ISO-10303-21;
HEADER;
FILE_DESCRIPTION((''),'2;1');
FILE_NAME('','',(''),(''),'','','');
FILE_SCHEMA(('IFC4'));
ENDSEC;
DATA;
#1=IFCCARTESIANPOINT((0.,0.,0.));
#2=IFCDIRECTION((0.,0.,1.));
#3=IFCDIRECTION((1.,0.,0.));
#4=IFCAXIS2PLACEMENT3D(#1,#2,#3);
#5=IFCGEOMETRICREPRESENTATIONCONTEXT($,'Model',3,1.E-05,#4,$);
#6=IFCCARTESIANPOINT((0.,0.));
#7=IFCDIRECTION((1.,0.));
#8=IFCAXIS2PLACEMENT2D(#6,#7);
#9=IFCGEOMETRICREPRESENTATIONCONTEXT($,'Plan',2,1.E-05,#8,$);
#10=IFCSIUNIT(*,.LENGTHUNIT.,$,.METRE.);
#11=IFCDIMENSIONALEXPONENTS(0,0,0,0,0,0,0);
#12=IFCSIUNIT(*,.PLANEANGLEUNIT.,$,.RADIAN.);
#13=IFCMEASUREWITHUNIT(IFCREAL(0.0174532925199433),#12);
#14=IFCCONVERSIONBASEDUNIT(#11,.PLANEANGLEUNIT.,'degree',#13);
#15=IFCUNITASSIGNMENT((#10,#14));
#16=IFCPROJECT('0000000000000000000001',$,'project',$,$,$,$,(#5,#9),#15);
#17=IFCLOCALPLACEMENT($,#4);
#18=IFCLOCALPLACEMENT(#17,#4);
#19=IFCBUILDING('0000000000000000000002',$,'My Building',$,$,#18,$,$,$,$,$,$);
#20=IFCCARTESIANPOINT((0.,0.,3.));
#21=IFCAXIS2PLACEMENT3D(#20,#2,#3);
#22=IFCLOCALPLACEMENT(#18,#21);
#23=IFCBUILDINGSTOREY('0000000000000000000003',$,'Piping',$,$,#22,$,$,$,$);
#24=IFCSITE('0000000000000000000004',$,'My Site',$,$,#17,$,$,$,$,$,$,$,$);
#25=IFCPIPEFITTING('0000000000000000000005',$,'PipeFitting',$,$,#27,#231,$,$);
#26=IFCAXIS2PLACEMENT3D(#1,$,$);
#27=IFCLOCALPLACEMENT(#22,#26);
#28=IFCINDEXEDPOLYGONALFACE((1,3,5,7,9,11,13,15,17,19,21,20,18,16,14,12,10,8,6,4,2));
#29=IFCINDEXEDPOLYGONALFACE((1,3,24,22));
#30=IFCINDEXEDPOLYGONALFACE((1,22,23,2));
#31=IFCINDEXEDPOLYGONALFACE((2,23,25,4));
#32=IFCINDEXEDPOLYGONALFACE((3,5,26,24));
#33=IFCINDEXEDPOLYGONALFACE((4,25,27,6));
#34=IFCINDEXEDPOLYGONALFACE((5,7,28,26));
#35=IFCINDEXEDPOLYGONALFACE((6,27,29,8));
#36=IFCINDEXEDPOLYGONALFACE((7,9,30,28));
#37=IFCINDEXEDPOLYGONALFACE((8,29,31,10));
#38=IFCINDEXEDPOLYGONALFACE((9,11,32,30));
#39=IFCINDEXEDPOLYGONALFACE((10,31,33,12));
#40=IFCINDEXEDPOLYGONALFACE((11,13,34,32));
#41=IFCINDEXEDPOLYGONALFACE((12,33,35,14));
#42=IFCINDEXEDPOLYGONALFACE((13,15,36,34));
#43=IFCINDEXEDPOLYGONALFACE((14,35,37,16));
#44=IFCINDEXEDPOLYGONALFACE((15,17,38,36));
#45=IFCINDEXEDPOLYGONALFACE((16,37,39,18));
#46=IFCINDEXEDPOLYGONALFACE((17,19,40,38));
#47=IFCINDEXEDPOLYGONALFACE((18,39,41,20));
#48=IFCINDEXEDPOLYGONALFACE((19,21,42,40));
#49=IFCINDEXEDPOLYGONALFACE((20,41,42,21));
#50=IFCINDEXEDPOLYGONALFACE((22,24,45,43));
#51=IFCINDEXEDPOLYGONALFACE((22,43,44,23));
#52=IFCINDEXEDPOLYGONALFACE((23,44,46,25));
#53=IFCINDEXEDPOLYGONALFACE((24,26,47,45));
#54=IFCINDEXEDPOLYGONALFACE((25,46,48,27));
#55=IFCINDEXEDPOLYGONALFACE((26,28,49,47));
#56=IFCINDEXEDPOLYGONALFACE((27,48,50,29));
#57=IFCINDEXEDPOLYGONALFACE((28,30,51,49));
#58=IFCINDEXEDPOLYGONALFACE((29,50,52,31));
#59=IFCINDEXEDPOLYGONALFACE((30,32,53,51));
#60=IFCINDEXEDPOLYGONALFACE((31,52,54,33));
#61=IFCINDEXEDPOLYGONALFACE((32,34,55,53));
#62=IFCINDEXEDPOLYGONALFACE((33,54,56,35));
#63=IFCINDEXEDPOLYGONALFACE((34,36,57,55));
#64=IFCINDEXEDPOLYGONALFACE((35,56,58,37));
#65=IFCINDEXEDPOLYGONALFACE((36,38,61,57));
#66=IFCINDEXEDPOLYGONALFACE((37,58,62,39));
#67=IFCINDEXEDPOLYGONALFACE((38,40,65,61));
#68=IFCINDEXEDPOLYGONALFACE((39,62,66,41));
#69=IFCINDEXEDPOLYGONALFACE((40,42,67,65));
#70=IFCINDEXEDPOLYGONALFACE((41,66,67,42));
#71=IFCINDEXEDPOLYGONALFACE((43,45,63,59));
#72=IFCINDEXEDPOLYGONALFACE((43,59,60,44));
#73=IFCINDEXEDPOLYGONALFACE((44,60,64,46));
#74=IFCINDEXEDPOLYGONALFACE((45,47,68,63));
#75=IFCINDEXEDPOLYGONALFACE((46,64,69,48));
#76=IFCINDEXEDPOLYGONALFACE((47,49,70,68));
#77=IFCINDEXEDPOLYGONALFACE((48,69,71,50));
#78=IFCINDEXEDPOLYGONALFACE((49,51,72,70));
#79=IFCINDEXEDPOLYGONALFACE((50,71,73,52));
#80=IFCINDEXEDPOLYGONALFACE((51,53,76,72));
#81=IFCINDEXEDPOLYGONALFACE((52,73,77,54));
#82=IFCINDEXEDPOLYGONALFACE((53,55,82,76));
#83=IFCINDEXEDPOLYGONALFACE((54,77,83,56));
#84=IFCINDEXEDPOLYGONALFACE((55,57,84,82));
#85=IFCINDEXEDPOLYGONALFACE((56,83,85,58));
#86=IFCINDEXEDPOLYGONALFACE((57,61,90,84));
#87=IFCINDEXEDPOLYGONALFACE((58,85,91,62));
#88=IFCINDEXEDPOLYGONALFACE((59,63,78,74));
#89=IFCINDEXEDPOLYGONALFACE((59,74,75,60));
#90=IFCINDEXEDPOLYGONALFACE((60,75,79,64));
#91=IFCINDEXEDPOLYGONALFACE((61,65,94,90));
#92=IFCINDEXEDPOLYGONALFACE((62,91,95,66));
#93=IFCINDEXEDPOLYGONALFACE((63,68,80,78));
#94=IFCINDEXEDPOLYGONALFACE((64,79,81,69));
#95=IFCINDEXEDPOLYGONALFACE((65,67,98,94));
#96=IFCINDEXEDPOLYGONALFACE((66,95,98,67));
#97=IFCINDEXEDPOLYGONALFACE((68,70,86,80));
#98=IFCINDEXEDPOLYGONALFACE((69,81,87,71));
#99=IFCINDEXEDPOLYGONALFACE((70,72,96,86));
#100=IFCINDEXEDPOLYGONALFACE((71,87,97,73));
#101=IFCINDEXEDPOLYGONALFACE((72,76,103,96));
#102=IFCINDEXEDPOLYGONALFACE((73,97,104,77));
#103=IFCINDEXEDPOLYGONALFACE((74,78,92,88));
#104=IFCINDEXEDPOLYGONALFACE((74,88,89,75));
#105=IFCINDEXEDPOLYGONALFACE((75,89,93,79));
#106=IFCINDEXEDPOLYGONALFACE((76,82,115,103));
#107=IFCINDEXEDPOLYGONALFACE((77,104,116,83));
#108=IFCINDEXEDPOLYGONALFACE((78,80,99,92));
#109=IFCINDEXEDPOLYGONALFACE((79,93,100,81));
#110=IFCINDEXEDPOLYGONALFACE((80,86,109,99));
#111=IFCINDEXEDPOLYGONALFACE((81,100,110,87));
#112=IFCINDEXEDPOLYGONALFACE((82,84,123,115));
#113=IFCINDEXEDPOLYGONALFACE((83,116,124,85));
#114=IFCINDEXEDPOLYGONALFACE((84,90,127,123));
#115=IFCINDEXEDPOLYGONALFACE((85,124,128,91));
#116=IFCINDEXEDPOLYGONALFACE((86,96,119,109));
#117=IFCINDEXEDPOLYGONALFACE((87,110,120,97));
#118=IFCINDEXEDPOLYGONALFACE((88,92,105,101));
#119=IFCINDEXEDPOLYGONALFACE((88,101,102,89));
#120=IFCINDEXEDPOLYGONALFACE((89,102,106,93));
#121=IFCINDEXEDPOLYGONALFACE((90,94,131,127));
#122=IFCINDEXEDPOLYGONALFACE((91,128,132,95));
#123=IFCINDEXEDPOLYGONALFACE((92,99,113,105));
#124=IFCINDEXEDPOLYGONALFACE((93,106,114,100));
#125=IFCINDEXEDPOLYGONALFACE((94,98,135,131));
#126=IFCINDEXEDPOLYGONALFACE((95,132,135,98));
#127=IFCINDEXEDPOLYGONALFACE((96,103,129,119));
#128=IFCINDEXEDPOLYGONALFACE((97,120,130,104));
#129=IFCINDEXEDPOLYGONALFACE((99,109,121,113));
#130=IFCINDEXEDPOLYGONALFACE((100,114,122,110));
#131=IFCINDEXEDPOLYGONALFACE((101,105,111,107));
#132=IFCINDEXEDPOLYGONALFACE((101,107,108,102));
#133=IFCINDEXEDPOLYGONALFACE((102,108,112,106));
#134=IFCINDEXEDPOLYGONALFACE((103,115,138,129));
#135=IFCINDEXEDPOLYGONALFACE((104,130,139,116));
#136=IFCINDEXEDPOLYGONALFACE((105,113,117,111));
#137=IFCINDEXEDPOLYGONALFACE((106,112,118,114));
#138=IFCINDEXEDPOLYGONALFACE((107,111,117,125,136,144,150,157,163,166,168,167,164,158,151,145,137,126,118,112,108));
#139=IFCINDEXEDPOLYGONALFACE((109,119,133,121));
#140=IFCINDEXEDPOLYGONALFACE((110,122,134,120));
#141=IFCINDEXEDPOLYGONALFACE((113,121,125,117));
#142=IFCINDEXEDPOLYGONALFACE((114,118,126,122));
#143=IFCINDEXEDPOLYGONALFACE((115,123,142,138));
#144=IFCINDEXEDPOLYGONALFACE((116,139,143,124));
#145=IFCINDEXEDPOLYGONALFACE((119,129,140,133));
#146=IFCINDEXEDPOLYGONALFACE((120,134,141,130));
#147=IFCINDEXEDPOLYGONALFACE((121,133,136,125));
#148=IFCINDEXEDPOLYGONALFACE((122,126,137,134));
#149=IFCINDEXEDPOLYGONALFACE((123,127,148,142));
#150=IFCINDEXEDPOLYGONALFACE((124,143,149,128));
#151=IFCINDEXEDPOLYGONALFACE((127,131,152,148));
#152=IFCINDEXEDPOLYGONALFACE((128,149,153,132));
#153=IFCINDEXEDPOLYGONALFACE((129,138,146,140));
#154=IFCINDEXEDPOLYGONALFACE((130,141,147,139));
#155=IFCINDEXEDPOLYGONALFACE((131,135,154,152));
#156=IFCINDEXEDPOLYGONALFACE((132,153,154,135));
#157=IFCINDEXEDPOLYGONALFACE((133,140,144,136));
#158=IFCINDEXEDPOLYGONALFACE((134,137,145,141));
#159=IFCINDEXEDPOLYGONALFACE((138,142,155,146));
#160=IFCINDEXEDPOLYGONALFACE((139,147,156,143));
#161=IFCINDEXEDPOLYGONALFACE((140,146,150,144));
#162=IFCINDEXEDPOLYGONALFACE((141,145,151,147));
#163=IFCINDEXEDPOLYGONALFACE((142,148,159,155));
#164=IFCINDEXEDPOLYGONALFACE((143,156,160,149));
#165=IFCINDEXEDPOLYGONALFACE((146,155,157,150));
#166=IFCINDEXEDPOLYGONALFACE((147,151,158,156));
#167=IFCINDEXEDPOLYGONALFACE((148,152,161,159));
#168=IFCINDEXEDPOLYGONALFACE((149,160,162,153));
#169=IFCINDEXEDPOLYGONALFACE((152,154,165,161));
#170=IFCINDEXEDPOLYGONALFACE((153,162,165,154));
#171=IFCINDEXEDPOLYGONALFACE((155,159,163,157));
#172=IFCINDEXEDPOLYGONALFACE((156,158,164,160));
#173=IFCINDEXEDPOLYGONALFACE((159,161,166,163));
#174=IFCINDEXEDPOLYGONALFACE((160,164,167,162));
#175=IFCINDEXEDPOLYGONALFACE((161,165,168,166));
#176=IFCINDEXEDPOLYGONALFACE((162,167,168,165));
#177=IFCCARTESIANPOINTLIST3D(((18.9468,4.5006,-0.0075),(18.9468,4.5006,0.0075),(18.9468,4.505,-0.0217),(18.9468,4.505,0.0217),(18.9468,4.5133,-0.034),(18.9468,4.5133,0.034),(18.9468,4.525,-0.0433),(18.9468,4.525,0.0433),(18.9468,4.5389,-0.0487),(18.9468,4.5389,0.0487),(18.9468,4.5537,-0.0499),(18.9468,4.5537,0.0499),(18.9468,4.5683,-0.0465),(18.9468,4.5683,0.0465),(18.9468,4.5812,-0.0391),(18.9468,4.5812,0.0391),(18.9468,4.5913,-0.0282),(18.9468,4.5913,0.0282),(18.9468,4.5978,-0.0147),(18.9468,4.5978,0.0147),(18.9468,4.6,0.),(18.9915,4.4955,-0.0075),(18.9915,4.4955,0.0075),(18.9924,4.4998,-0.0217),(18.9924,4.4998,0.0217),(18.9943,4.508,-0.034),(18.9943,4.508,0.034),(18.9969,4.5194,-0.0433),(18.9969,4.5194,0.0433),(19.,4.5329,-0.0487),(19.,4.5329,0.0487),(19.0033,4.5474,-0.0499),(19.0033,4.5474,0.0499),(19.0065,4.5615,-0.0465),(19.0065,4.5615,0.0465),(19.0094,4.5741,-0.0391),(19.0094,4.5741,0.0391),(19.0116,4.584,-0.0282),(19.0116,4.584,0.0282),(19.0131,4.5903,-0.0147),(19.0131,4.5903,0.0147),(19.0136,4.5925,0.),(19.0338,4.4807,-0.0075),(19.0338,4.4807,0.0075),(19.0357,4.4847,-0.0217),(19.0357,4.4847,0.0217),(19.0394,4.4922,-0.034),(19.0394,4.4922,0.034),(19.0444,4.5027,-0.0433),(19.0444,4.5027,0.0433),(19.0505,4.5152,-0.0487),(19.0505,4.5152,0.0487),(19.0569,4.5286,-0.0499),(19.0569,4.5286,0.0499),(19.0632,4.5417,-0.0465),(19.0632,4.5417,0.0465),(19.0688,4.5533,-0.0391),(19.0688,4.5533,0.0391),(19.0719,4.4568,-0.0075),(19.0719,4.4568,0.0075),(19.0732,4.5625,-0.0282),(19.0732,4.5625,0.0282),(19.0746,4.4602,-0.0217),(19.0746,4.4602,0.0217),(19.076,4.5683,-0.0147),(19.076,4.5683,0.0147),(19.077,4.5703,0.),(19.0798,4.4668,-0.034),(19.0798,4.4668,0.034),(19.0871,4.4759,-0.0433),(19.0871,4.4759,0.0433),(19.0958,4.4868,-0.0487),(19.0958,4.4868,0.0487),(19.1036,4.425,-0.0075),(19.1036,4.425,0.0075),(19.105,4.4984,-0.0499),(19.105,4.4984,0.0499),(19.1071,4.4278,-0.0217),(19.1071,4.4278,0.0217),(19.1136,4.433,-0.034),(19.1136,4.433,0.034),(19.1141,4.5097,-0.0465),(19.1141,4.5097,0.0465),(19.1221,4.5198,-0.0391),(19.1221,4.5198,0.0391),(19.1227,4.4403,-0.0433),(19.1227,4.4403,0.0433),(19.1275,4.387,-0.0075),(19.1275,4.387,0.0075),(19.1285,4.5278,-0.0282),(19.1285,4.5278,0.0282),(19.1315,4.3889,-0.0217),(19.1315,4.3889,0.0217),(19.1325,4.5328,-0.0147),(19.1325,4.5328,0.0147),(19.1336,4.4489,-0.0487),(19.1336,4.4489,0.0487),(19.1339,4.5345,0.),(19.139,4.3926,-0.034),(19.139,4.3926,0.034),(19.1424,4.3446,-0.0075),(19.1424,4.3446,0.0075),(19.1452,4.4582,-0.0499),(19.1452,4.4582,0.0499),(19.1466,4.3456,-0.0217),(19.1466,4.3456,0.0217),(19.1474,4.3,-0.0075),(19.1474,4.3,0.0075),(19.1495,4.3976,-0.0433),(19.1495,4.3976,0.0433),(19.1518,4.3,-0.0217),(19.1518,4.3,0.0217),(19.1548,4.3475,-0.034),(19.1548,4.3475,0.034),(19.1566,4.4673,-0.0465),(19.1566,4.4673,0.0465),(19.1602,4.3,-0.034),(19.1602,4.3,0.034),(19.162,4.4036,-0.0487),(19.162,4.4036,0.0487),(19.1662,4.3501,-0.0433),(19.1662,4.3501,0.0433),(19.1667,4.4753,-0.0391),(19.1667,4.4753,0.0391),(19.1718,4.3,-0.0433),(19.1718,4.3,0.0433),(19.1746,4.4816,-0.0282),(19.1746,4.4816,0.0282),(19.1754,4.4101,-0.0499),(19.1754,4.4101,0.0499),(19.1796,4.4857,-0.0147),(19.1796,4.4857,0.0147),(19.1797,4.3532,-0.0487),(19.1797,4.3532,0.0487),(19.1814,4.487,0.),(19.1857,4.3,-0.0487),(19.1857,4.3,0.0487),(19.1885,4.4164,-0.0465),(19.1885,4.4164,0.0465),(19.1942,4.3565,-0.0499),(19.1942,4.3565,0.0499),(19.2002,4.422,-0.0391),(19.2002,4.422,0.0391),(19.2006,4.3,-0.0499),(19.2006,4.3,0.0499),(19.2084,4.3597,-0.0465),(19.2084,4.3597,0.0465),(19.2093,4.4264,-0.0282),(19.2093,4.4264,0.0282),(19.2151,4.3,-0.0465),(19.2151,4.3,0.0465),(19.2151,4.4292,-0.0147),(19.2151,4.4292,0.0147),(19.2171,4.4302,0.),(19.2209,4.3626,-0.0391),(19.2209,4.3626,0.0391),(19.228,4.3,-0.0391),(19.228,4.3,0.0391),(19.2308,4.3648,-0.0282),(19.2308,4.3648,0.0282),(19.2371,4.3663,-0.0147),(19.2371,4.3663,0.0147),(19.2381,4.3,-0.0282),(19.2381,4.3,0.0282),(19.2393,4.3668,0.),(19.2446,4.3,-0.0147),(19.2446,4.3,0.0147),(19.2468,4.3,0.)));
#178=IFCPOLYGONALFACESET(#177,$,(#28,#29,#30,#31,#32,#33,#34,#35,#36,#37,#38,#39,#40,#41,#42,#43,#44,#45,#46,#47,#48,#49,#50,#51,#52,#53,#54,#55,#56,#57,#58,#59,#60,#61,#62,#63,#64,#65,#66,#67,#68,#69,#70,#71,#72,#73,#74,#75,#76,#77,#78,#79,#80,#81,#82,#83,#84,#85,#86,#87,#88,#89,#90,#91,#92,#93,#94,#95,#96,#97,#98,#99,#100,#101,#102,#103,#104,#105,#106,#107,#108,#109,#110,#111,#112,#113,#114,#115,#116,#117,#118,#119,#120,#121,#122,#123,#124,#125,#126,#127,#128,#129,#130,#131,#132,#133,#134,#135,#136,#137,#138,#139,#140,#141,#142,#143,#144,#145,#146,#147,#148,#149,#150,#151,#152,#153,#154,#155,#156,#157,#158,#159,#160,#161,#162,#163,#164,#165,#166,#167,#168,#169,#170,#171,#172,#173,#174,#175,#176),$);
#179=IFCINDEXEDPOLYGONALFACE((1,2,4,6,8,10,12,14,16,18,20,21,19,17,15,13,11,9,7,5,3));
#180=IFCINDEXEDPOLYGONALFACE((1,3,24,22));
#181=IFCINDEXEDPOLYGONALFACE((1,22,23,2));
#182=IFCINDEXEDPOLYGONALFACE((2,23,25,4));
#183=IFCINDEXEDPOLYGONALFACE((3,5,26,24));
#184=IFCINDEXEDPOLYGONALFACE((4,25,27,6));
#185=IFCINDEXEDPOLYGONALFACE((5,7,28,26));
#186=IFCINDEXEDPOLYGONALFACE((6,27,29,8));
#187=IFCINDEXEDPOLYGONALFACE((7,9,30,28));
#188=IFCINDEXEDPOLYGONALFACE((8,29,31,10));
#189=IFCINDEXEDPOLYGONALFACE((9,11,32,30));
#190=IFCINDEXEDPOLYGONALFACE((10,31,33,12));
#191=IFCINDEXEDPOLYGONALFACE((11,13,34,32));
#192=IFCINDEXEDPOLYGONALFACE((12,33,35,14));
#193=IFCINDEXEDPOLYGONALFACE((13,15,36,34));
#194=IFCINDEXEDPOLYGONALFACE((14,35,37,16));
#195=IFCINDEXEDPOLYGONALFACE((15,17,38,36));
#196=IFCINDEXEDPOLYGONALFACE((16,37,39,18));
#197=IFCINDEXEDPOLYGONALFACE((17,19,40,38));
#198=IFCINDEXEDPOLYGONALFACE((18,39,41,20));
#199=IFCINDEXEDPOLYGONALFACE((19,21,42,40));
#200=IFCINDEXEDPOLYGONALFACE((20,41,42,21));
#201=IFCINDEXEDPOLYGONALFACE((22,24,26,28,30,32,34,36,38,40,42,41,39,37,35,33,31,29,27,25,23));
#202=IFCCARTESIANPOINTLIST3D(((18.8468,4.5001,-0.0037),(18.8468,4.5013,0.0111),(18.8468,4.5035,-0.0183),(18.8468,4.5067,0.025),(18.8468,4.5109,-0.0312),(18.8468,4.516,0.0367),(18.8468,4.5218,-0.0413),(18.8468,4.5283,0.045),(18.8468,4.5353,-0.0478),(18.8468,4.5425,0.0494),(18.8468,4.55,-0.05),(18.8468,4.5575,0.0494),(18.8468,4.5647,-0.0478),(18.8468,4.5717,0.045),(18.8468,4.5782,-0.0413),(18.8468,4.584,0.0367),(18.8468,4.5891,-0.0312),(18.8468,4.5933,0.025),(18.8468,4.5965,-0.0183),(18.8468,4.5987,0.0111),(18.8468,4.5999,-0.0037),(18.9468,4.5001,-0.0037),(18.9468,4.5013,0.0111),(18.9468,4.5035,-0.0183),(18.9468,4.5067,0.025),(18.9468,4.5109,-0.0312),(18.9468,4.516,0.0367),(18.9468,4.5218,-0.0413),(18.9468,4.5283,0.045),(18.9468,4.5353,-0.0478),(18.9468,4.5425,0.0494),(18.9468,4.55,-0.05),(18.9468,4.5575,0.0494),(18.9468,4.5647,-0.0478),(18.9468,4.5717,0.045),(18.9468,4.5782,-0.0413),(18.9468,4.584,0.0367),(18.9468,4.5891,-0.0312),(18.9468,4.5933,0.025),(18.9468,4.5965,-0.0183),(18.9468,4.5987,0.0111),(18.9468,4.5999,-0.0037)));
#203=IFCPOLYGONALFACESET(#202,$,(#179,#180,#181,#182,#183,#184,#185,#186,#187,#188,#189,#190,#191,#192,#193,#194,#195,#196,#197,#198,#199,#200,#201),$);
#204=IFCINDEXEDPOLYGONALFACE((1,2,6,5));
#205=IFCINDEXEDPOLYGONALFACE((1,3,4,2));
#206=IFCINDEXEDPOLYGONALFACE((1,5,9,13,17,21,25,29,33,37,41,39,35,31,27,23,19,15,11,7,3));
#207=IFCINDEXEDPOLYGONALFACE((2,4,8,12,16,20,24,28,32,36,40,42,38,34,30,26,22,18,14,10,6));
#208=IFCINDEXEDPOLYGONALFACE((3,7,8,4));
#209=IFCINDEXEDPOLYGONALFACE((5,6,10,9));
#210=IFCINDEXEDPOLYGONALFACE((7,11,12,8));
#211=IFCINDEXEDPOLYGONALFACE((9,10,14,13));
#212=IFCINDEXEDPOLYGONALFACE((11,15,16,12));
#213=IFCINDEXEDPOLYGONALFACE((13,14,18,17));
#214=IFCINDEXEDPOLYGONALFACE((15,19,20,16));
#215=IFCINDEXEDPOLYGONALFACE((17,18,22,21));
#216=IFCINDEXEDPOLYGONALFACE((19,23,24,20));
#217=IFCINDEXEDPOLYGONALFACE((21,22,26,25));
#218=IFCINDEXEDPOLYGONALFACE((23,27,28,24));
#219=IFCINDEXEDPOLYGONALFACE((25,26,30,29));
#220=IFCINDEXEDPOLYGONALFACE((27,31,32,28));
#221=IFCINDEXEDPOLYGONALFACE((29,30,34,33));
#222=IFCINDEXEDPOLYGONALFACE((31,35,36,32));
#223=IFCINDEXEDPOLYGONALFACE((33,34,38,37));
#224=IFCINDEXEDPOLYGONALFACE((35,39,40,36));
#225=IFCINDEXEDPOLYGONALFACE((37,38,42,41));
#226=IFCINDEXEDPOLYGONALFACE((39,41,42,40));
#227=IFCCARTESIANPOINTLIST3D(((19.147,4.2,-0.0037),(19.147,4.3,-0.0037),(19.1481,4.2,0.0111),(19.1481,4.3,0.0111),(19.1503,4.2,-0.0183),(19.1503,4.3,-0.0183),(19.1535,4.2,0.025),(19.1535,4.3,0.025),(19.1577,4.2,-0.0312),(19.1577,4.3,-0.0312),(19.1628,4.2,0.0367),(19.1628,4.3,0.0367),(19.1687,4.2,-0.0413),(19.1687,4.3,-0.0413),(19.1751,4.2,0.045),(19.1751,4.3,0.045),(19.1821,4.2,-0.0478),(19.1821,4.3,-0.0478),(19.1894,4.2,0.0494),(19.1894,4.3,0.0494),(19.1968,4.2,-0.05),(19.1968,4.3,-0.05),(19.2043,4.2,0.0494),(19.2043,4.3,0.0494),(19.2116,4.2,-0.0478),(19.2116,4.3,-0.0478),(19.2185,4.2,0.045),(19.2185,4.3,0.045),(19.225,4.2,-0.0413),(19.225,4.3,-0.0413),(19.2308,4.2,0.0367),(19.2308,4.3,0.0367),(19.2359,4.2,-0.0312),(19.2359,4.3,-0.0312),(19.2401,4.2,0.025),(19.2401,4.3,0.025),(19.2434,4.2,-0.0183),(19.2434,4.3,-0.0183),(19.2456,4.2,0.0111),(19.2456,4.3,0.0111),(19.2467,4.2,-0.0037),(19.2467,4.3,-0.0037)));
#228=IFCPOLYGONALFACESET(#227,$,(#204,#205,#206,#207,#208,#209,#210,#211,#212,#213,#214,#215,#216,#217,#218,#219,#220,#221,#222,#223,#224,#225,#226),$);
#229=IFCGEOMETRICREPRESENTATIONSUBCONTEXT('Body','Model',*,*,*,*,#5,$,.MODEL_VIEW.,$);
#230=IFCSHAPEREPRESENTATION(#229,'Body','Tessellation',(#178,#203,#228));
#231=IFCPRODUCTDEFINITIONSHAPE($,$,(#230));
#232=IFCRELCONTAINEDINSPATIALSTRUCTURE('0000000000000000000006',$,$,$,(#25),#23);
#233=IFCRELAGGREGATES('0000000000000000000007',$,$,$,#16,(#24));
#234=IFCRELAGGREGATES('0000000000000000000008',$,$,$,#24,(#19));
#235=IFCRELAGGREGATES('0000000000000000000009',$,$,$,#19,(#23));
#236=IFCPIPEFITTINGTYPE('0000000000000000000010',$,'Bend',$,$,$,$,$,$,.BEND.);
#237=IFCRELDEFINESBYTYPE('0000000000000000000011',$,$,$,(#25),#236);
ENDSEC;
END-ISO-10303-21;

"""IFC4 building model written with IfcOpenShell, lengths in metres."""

from ifc_helpers import new_model, entity, si_unit, converted_unit, frame, origin_with_axes, origin_2d_with_axis, place, context, subcontext, project, spatial, circle, extrude, source, transform, mapped, type_object, type_shapes, element, save


model = new_model("IFC4")

# Units and contexts
model_context = context("Model", 3, precision=1e-05, world=origin_with_axes())
plan_context = context("Plan", 2, precision=1e-05, world=origin_2d_with_axis())
body_context = subcontext(model_context, "Body", "Model", "MODEL_VIEW")
ifc_project = project(units=[si_unit("LENGTHUNIT", "METRE"), converted_unit("PLANEANGLEUNIT", "degree", entity("IfcReal", 0.0174532925199433), si_unit("PLANEANGLEUNIT", "RADIAN"), dimensions=[0, 0, 0, 0, 0, 0, 0])], contexts=[model_context, plan_context])

# Site, building, storey
site_placement = place(None, origin_with_axes())
site = spatial("IfcSite", under=ifc_project, at=site_placement, Name="My Site")
building_placement = place(site_placement, origin_with_axes())
building = spatial("IfcBuilding", under=site, at=building_placement, Name="My Building")
storey_placement = place(building_placement, frame((0.0, 0.0, 3.0), z_axis=(0.0, 0.0, 1.0), x_axis=(1.0, 0.0, 0.0)))
storey = spatial("IfcBuildingStorey", under=building, at=storey_placement, Name="Piping")

# Pipe fitting
pipe_fitting_type = type_object("IfcPipeFittingType", Name="Bend", PredefinedType="BEND")
shared_shape = source(origin_with_axes(), body_context, "Body", "SolidModel", [
    entity("IfcSweptDiskSolid", entity("IfcIndexedPolyCurve", entity("IfcCartesianPointList3D", [[0.0, 0.0, 0.1], [0.0, -0.0732, 0.2768], [0.0, -0.25, 0.35]]), [entity("IfcArcIndex", [1, 2, 3])]), 0.05),
    extrude(circle(Radius=0.05), origin_with_axes(), (0.0, 0.0, 1.0), 0.1),
    extrude(circle(Radius=0.05), frame((0.0, -0.25, 0.35), z_axis=(0.0, -1.0, 0.0), x_axis=(1.0, 0.0, 0.0)), (0.0, 0.0, 1.0), 0.1),
])
type_shapes(pipe_fitting_type, [shared_shape])
for number, where, z_axis, x_axis, name in (
    (1, (18.8468, 4.55, 0.0), (1.0, 0.000001, 0.0), (0.0, 0.0, -1.0), "PipeFitting"),
):
    element("IfcPipeFitting", number, at=place(storey_placement, frame(where, z_axis=z_axis, x_axis=x_axis)), inside=storey, type_object=pipe_fitting_type, Name=name, context=body_context, shape_type="MappedRepresentation", body=[
        mapped(shared_shape, transform((0.0, 0.0, 0.0), x_axis=(1.0, 0.0, 0.0), y_axis=(0.0, 1.0, 0.0), z_axis=(0.0, 0.0, 1.0), scale=1.0)),
    ])

save(model, "model.ifc")
